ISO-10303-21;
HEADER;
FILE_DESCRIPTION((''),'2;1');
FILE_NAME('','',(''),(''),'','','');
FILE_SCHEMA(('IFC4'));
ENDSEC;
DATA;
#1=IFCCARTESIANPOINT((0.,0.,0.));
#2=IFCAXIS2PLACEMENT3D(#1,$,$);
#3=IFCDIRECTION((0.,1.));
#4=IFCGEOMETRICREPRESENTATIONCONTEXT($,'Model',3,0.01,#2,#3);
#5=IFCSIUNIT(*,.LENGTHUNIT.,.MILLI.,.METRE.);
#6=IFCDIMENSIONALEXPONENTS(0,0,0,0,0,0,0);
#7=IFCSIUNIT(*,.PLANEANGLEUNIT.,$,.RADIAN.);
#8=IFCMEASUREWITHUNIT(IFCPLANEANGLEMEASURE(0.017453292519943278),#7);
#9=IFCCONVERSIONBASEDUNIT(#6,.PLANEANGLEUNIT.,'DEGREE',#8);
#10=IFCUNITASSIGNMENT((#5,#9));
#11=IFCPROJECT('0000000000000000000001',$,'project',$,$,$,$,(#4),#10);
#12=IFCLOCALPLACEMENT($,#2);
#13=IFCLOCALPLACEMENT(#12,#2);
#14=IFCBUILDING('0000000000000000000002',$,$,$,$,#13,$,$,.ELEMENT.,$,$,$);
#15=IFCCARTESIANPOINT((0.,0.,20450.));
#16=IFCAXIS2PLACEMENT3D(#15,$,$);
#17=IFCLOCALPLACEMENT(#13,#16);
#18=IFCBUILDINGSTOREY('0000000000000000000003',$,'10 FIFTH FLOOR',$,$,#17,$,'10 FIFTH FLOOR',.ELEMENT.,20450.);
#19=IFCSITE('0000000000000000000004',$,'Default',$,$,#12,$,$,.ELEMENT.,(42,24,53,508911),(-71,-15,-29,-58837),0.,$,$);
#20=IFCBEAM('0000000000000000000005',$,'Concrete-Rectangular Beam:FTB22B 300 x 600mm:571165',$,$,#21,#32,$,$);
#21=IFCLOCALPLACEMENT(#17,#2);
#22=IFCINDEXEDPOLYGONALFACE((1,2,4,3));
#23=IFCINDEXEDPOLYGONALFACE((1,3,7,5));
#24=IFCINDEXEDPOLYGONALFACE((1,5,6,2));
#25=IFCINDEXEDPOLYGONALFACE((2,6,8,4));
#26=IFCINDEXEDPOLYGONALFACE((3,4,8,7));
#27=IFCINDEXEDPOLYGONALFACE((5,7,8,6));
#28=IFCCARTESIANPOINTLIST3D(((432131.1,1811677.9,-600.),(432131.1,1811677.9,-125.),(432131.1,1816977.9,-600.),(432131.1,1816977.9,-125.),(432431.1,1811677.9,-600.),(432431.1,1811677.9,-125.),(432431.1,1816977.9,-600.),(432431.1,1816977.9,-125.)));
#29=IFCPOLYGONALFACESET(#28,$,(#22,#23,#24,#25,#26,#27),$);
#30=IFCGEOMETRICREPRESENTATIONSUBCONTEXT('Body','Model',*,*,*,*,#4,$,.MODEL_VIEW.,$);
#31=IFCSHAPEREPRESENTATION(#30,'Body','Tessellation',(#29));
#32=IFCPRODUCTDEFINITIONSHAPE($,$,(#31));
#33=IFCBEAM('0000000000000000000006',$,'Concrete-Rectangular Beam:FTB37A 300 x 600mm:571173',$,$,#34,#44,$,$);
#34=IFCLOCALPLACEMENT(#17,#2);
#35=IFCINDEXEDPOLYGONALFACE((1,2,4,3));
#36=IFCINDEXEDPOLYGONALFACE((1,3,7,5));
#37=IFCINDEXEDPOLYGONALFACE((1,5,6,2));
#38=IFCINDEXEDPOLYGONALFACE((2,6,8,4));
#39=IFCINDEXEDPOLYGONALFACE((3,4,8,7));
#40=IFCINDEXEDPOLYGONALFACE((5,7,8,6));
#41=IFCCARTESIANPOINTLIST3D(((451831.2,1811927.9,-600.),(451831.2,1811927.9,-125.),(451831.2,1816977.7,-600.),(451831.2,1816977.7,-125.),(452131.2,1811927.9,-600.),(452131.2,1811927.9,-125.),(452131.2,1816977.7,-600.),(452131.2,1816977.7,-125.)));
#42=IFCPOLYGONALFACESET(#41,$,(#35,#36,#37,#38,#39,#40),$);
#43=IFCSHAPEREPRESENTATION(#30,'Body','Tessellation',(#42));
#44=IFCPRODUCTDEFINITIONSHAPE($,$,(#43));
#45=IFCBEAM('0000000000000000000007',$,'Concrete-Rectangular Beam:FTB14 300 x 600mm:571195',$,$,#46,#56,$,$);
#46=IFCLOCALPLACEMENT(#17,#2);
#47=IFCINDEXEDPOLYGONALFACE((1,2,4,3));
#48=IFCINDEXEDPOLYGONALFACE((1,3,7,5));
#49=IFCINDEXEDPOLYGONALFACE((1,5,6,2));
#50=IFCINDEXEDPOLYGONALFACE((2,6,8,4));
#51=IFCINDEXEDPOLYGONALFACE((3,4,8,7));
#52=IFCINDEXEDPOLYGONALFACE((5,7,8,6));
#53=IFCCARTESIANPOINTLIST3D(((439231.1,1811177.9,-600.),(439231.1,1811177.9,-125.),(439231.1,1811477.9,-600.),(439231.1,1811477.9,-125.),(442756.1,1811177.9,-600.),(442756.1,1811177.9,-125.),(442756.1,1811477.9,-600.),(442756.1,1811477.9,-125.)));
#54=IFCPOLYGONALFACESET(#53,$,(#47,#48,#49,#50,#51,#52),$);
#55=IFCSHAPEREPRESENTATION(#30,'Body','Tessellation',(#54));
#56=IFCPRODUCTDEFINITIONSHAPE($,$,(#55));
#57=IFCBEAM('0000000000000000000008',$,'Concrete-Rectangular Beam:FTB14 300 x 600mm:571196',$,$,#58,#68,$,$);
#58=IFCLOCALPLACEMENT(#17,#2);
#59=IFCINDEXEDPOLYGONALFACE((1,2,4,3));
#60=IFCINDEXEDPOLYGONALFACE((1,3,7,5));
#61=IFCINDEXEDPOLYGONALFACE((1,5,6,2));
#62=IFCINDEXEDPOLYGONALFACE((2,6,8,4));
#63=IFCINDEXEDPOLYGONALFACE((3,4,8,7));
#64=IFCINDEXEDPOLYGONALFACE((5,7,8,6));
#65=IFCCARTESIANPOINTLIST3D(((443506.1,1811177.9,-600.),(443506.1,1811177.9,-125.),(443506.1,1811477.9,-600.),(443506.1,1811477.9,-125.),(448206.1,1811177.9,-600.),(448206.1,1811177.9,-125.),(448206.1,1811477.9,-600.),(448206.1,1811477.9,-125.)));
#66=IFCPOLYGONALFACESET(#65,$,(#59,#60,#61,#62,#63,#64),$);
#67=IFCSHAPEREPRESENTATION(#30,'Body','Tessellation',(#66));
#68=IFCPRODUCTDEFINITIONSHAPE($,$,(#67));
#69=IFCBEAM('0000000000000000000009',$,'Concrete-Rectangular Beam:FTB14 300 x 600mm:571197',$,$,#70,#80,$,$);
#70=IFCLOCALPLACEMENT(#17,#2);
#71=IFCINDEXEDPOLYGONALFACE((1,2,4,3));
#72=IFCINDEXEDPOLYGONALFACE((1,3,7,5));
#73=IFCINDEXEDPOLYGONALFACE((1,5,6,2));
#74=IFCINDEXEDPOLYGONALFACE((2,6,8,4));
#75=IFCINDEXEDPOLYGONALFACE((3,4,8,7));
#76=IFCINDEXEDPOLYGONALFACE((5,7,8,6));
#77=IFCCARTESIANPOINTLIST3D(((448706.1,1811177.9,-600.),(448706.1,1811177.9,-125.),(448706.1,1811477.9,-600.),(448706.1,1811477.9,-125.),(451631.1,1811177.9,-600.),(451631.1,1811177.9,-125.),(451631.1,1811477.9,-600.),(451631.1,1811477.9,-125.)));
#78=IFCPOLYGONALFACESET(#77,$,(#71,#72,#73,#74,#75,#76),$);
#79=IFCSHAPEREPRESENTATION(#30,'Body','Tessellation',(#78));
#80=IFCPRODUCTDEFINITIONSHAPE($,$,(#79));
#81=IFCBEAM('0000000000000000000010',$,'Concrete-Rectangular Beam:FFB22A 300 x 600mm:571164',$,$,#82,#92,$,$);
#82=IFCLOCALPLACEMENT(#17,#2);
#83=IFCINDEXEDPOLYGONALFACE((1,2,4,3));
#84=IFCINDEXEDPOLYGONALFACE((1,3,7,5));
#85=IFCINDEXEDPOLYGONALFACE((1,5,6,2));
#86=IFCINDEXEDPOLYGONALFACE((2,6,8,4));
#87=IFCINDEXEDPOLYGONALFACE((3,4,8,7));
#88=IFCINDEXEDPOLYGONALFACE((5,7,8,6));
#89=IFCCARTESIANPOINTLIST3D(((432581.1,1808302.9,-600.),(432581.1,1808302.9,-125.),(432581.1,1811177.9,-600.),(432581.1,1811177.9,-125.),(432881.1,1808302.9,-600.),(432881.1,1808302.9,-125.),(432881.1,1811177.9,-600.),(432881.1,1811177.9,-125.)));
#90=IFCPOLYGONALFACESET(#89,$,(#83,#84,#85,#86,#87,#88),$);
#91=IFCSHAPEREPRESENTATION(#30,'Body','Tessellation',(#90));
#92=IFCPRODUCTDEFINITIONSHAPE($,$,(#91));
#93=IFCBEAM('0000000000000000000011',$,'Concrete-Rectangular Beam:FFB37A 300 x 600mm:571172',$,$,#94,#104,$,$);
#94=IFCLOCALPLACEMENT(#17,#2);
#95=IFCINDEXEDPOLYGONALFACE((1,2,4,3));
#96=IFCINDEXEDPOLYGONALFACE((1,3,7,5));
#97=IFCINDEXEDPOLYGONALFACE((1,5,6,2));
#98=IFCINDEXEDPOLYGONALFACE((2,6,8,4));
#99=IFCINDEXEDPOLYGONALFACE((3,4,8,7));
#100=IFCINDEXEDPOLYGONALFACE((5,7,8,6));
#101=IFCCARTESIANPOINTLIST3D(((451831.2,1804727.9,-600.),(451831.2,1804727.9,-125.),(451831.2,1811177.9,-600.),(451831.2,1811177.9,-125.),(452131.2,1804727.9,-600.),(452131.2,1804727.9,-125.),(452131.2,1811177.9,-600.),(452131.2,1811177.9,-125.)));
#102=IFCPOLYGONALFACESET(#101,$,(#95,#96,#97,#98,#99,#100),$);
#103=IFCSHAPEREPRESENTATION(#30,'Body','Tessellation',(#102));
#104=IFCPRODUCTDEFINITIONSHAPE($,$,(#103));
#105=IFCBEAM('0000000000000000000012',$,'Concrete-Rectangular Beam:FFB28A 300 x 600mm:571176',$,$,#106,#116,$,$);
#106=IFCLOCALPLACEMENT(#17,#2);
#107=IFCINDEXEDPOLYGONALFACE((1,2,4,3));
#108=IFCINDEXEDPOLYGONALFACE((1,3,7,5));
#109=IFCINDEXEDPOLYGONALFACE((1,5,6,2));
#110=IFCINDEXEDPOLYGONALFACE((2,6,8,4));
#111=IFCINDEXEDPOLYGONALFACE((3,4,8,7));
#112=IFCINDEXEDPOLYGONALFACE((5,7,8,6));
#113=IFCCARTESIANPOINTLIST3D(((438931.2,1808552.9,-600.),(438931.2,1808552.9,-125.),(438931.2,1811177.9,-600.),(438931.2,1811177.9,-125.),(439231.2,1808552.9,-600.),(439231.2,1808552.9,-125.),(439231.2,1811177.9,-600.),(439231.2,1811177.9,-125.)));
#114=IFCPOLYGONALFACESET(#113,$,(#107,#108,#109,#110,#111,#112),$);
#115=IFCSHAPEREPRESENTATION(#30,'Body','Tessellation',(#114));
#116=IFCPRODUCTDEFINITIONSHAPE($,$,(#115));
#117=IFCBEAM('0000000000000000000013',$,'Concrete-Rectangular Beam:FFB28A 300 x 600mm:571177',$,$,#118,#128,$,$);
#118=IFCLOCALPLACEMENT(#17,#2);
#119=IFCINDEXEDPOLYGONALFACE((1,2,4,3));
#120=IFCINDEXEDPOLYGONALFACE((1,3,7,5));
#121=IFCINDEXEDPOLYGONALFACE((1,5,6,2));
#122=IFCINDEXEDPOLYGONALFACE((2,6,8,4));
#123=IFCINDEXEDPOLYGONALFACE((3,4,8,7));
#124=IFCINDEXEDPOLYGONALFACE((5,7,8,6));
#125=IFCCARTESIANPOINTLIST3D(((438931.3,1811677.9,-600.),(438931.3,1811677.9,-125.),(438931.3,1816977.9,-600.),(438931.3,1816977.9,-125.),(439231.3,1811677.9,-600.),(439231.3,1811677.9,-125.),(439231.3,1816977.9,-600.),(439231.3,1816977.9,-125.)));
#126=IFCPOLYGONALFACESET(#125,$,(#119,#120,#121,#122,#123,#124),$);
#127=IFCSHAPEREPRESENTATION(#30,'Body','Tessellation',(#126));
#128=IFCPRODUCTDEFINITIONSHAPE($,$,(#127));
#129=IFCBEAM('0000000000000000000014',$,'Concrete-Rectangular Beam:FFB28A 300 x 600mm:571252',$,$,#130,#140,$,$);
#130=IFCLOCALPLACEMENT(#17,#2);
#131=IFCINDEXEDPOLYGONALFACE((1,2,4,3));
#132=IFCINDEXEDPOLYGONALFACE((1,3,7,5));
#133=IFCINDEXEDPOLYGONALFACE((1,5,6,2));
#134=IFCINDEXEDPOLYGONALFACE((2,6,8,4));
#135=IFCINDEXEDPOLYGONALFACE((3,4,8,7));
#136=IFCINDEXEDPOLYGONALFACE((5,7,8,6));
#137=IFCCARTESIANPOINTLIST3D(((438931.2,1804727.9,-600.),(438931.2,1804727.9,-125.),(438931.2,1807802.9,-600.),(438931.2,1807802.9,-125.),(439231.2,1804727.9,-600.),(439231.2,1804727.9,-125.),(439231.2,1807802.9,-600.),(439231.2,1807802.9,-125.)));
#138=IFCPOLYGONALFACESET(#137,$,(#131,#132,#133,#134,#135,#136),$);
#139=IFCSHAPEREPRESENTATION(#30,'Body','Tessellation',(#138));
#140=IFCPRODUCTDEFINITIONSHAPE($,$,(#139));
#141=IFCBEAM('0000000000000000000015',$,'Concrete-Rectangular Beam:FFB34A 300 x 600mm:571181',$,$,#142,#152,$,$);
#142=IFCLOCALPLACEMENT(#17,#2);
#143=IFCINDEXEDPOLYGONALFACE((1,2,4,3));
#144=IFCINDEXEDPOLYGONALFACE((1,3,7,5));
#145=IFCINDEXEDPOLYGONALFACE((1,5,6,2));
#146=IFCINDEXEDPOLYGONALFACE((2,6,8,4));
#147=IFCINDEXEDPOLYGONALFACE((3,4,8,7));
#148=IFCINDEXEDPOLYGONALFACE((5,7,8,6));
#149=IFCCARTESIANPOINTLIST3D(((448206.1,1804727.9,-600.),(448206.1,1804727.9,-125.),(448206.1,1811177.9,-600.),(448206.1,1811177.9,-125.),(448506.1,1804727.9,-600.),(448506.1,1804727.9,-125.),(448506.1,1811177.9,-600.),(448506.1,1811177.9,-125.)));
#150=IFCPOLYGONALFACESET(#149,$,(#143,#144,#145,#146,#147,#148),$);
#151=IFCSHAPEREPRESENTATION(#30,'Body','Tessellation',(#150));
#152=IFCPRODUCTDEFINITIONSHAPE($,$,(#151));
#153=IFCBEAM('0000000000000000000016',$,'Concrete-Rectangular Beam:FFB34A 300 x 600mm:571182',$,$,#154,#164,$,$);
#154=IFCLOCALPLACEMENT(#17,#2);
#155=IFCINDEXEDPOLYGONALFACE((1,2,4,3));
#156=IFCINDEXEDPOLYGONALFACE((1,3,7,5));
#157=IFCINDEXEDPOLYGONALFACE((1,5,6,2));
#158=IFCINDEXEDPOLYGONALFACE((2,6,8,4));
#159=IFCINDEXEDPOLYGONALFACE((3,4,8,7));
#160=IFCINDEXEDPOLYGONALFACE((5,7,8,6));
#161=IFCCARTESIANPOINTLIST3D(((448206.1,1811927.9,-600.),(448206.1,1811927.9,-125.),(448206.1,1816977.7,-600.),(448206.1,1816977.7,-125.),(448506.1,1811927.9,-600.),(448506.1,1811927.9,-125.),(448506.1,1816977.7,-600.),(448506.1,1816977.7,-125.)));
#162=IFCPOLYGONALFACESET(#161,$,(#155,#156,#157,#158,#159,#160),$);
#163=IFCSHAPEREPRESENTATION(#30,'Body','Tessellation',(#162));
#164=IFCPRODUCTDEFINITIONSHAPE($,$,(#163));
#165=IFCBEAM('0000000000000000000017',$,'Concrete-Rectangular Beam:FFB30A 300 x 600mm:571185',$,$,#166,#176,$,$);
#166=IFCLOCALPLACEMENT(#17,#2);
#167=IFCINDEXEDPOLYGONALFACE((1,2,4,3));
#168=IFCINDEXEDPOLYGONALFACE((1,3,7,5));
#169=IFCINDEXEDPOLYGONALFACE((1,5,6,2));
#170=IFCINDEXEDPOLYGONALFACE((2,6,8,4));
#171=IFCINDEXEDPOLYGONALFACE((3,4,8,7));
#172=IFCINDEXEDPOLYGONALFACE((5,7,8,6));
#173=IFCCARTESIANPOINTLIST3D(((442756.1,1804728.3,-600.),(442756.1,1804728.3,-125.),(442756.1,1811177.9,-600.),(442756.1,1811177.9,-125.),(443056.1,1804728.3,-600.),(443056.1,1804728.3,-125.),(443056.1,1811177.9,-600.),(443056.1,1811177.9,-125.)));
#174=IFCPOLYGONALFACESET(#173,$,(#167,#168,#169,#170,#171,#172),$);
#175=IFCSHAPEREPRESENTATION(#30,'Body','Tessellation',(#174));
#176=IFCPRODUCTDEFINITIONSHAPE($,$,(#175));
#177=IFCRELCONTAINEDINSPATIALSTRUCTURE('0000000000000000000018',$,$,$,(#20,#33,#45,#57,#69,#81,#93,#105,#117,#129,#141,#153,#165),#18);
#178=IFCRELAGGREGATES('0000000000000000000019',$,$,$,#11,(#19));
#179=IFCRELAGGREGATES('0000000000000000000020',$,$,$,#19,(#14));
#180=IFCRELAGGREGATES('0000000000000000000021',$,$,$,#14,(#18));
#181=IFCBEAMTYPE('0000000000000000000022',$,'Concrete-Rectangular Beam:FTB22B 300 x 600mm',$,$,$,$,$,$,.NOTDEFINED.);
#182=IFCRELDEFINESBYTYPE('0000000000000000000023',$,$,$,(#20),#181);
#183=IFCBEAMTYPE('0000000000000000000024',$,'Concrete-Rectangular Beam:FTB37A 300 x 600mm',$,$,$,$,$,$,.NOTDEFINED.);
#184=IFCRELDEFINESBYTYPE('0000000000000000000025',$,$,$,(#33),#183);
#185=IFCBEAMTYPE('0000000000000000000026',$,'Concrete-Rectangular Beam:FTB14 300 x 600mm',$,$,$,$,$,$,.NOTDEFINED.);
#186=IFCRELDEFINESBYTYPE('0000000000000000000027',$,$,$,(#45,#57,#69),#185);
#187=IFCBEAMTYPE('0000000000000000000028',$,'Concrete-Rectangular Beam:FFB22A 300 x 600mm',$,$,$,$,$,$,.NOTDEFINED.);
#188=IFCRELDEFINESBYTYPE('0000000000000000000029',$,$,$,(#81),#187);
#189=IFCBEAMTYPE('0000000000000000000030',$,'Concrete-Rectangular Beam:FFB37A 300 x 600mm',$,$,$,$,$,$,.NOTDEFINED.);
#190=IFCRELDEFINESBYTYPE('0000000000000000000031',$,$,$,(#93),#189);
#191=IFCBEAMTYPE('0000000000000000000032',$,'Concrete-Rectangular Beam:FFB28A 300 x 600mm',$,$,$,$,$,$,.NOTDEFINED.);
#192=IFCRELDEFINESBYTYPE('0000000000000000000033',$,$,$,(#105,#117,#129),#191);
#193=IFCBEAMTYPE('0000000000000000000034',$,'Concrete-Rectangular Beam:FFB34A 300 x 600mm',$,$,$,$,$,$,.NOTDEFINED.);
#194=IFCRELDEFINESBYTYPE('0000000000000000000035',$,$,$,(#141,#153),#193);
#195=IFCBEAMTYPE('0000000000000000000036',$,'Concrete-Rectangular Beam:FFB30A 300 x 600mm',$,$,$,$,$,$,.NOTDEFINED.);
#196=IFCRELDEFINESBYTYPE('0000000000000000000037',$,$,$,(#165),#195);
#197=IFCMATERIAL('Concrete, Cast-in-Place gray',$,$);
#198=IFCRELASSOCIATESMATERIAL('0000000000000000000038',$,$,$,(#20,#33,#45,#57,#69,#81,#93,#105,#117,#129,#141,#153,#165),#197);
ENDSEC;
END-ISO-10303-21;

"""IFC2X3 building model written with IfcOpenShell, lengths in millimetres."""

from ifc_helpers import new_model, entity, si_unit, converted_unit, direction, frame, frame_2d, origin, place, context, subcontext, project, spatial, rectangle, extrude, material, type_object, element, save


model = new_model("IFC2X3")

# Units and contexts
model_context = context("Model", 3, precision=0.01, world=origin(), true_north=direction((0.0, 1.0)))
body_context = subcontext(model_context, "Body", "Model", "MODEL_VIEW")
ifc_project = project(units=[si_unit("LENGTHUNIT", "METRE", prefix="MILLI"), converted_unit("PLANEANGLEUNIT", "DEGREE", entity("IfcPlaneAngleMeasure", 0.017453292519943278), si_unit("PLANEANGLEUNIT", "RADIAN"), dimensions=[0, 0, 0, 0, 0, 0, 0])], contexts=[model_context])

# Site, building, storey
site_placement = place(None, origin())
site = spatial("IfcSite", under=ifc_project, at=site_placement, Name="Default", CompositionType="ELEMENT", RefLatitude=(42, 24, 53, 508911), RefLongitude=(-71, -15, -29, -58837), RefElevation=0.0)
building_placement = place(site_placement, origin())
building = spatial("IfcBuilding", under=site, at=building_placement, CompositionType="ELEMENT")
storey_placement = place(building_placement, frame((0.0, 0.0, 20450.0)))
storey = spatial("IfcBuildingStorey", under=building, at=storey_placement, Name="10 FIFTH FLOOR", LongName="10 FIFTH FLOOR", CompositionType="ELEMENT", Elevation=20450.0)

# Beams
ifc_material = material(Name="Concrete, Cast-in-Place gray")
beam_type_1 = type_object("IfcBeamType", Name="Concrete-Rectangular Beam:FTB22B 300 x 600mm", PredefinedType="NOTDEFINED")
beam_1_placement = place(storey_placement, frame((432431.1, 1811677.9, 0.0), z_axis=(0.0, 0.0, 1.0), x_axis=(0.0, 1.0, 0.0)))
element("IfcBeam", 1, at=beam_1_placement, inside=storey, type_object=beam_type_1, material=ifc_material, Name="Concrete-Rectangular Beam:FTB22B 300 x 600mm:571165", context=body_context, shape_type="SweptSolid", body=[
    extrude(rectangle(XDim=475.0, YDim=300.0, at=frame_2d((0.0, 0.0), x_axis=(1.0, 0.0))), frame((0.0, 150.0, -362.5), z_axis=(1.0, 0.0, 0.0), x_axis=(0.0, 0.0, -1.0)), (0.0, 0.0, 1.0), 5300.0),
])
beam_type_2 = type_object("IfcBeamType", Name="Concrete-Rectangular Beam:FTB37A 300 x 600mm", PredefinedType="NOTDEFINED")
beam_2_placement = place(storey_placement, frame((451831.2, 1811927.9, 0.0), z_axis=(0.0, 0.0, 1.0), x_axis=(0.0, 1.0, 0.0)))
element("IfcBeam", 2, at=beam_2_placement, inside=storey, type_object=beam_type_2, material=ifc_material, Name="Concrete-Rectangular Beam:FTB37A 300 x 600mm:571173", context=body_context, shape_type="SweptSolid", body=[
    extrude(rectangle(XDim=475.0, YDim=300.0, at=frame_2d((0.0, 0.0), x_axis=(1.0, 0.0))), frame((0.0, -150.0, -362.5), z_axis=(1.0, 0.0, 0.0), x_axis=(0.0, 0.0, -1.0)), (0.0, 0.0, 1.0), 5049.8),
])
beam_type_3 = type_object("IfcBeamType", Name="Concrete-Rectangular Beam:FTB14 300 x 600mm", PredefinedType="NOTDEFINED")
beam_3_placement = place(storey_placement, frame((439231.1, 1811177.9, 0.0)))
element("IfcBeam", 3, at=beam_3_placement, inside=storey, type_object=beam_type_3, material=ifc_material, Name="Concrete-Rectangular Beam:FTB14 300 x 600mm:571195", context=body_context, shape_type="SweptSolid", body=[
    extrude(rectangle(XDim=475.0, YDim=300.0, at=frame_2d((0.0, 0.0), x_axis=(1.0, 0.0))), frame((0.0, 150.0, -362.5), z_axis=(1.0, 0.0, 0.0), x_axis=(0.0, 0.0, -1.0)), (0.0, 0.0, 1.0), 3525.0),
])
beam_4_placement = place(storey_placement, frame((443506.1, 1811177.9, 0.0)))
element("IfcBeam", 4, at=beam_4_placement, inside=storey, type_object=beam_type_3, material=ifc_material, Name="Concrete-Rectangular Beam:FTB14 300 x 600mm:571196", context=body_context, shape_type="SweptSolid", body=[
    extrude(rectangle(XDim=475.0, YDim=300.0, at=frame_2d((0.0, 0.0), x_axis=(1.0, 0.0))), frame((0.0, 150.0, -362.5), z_axis=(1.0, 0.0, 0.0), x_axis=(0.0, 0.0, -1.0)), (0.0, 0.0, 1.0), 4700.0),
])
beam_5_placement = place(storey_placement, frame((448706.1, 1811177.9, 0.0)))
element("IfcBeam", 5, at=beam_5_placement, inside=storey, type_object=beam_type_3, material=ifc_material, Name="Concrete-Rectangular Beam:FTB14 300 x 600mm:571197", context=body_context, shape_type="SweptSolid", body=[
    extrude(rectangle(XDim=475.0, YDim=300.0, at=frame_2d((0.0, 0.0), x_axis=(1.0, 0.0))), frame((0.0, 150.0, -362.5), z_axis=(1.0, 0.0, 0.0), x_axis=(0.0, 0.0, -1.0)), (0.0, 0.0, 1.0), 2925.0),
])
beam_type_4 = type_object("IfcBeamType", Name="Concrete-Rectangular Beam:FFB22A 300 x 600mm", PredefinedType="NOTDEFINED")
beam_6_placement = place(storey_placement, frame((432881.1, 1808302.9, 0.0), z_axis=(0.0, 0.0, 1.0), x_axis=(0.0, 1.0, 0.0)))
element("IfcBeam", 6, at=beam_6_placement, inside=storey, type_object=beam_type_4, material=ifc_material, Name="Concrete-Rectangular Beam:FFB22A 300 x 600mm:571164", context=body_context, shape_type="SweptSolid", body=[
    extrude(rectangle(XDim=475.0, YDim=300.0, at=frame_2d((0.0, 0.0), x_axis=(1.0, 0.0))), frame((0.0, 150.0, -362.5), z_axis=(1.0, 0.0, 0.0), x_axis=(0.0, 0.0, -1.0)), (0.0, 0.0, 1.0), 2875.0),
])
beam_type_5 = type_object("IfcBeamType", Name="Concrete-Rectangular Beam:FFB37A 300 x 600mm", PredefinedType="NOTDEFINED")
beam_7_placement = place(storey_placement, frame((451831.2, 1804727.9, 0.0), z_axis=(0.0, 0.0, 1.0), x_axis=(0.0, 1.0, 0.0)))
element("IfcBeam", 7, at=beam_7_placement, inside=storey, type_object=beam_type_5, material=ifc_material, Name="Concrete-Rectangular Beam:FFB37A 300 x 600mm:571172", context=body_context, shape_type="SweptSolid", body=[
    extrude(rectangle(XDim=475.0, YDim=300.0, at=frame_2d((0.0, 0.0), x_axis=(1.0, 0.0))), frame((0.0, -150.0, -362.5), z_axis=(1.0, 0.0, 0.0), x_axis=(0.0, 0.0, -1.0)), (0.0, 0.0, 1.0), 6450.0),
])
beam_type_6 = type_object("IfcBeamType", Name="Concrete-Rectangular Beam:FFB28A 300 x 600mm", PredefinedType="NOTDEFINED")
beam_8_placement = place(storey_placement, frame((438931.2, 1808552.9, 0.0), z_axis=(0.0, 0.0, 1.0), x_axis=(0.0, 1.0, 0.0)))
element("IfcBeam", 8, at=beam_8_placement, inside=storey, type_object=beam_type_6, material=ifc_material, Name="Concrete-Rectangular Beam:FFB28A 300 x 600mm:571176", context=body_context, shape_type="SweptSolid", body=[
    extrude(rectangle(XDim=475.0, YDim=300.0, at=frame_2d((0.0, 0.0), x_axis=(1.0, 0.0))), frame((0.0, -150.0, -362.5), z_axis=(1.0, 0.0, 0.0), x_axis=(0.0, 0.0, -1.0)), (0.0, 0.0, 1.0), 2625.0),
])
beam_9_placement = place(storey_placement, frame((438931.3, 1811677.9, 0.0), z_axis=(0.0, 0.0, 1.0), x_axis=(0.0, 1.0, 0.0)))
element("IfcBeam", 9, at=beam_9_placement, inside=storey, type_object=beam_type_6, material=ifc_material, Name="Concrete-Rectangular Beam:FFB28A 300 x 600mm:571177", context=body_context, shape_type="SweptSolid", body=[
    extrude(rectangle(XDim=475.0, YDim=300.0, at=frame_2d((0.0, 0.0), x_axis=(1.0, 0.0))), frame((0.0, -150.0, -362.5), z_axis=(1.0, 0.0, 0.0), x_axis=(0.0, 0.0, -1.0)), (0.0, 0.0, 1.0), 5300.0),
])
beam_10_placement = place(storey_placement, frame((439231.2, 1807802.9, 0.0), z_axis=(0.0, 0.0, 1.0), x_axis=(0.0, -1.0, 0.0)))
element("IfcBeam", 10, at=beam_10_placement, inside=storey, type_object=beam_type_6, material=ifc_material, Name="Concrete-Rectangular Beam:FFB28A 300 x 600mm:571252", context=body_context, shape_type="SweptSolid", body=[
    extrude(rectangle(XDim=475.0, YDim=300.0, at=frame_2d((0.0, 0.0), x_axis=(1.0, 0.0))), frame((0.0, -150.0, -362.5), z_axis=(1.0, 0.0, 0.0), x_axis=(0.0, 0.0, -1.0)), (0.0, 0.0, 1.0), 3075.0),
])
beam_type_7 = type_object("IfcBeamType", Name="Concrete-Rectangular Beam:FFB34A 300 x 600mm", PredefinedType="NOTDEFINED")
beam_11_placement = place(storey_placement, frame((448206.1, 1804727.9, 0.0), z_axis=(0.0, 0.0, 1.0), x_axis=(0.0, 1.0, 0.0)))
element("IfcBeam", 11, at=beam_11_placement, inside=storey, type_object=beam_type_7, material=ifc_material, Name="Concrete-Rectangular Beam:FFB34A 300 x 600mm:571181", context=body_context, shape_type="SweptSolid", body=[
    extrude(rectangle(XDim=475.0, YDim=300.0, at=frame_2d((0.0, 0.0), x_axis=(1.0, 0.0))), frame((0.0, -150.0, -362.5), z_axis=(1.0, 0.0, 0.0), x_axis=(0.0, 0.0, -1.0)), (0.0, 0.0, 1.0), 6450.0),
])
beam_12_placement = place(storey_placement, frame((448206.1, 1811927.9, 0.0), z_axis=(0.0, 0.0, 1.0), x_axis=(0.0, 1.0, 0.0)))
element("IfcBeam", 12, at=beam_12_placement, inside=storey, type_object=beam_type_7, material=ifc_material, Name="Concrete-Rectangular Beam:FFB34A 300 x 600mm:571182", context=body_context, shape_type="SweptSolid", body=[
    extrude(rectangle(XDim=475.0, YDim=300.0, at=frame_2d((0.0, 0.0), x_axis=(1.0, 0.0))), frame((0.0, -150.0, -362.5), z_axis=(1.0, 0.0, 0.0), x_axis=(0.0, 0.0, -1.0)), (0.0, 0.0, 1.0), 5049.8),
])
beam_type_8 = type_object("IfcBeamType", Name="Concrete-Rectangular Beam:FFB30A 300 x 600mm", PredefinedType="NOTDEFINED")
beam_13_placement = place(storey_placement, frame((442756.1, 1804728.3, 0.0), z_axis=(0.0, 0.0, 1.0), x_axis=(0.0, 1.0, 0.0)))
element("IfcBeam", 13, at=beam_13_placement, inside=storey, type_object=beam_type_8, material=ifc_material, Name="Concrete-Rectangular Beam:FFB30A 300 x 600mm:571185", context=body_context, shape_type="SweptSolid", body=[
    extrude(rectangle(XDim=475.0, YDim=300.0, at=frame_2d((0.0, 0.0), x_axis=(1.0, 0.0))), frame((0.0, -150.0, -362.5), z_axis=(1.0, 0.0, 0.0), x_axis=(0.0, 0.0, -1.0)), (0.0, 0.0, 1.0), 6449.6),
])

save(model, "model.ifc")
